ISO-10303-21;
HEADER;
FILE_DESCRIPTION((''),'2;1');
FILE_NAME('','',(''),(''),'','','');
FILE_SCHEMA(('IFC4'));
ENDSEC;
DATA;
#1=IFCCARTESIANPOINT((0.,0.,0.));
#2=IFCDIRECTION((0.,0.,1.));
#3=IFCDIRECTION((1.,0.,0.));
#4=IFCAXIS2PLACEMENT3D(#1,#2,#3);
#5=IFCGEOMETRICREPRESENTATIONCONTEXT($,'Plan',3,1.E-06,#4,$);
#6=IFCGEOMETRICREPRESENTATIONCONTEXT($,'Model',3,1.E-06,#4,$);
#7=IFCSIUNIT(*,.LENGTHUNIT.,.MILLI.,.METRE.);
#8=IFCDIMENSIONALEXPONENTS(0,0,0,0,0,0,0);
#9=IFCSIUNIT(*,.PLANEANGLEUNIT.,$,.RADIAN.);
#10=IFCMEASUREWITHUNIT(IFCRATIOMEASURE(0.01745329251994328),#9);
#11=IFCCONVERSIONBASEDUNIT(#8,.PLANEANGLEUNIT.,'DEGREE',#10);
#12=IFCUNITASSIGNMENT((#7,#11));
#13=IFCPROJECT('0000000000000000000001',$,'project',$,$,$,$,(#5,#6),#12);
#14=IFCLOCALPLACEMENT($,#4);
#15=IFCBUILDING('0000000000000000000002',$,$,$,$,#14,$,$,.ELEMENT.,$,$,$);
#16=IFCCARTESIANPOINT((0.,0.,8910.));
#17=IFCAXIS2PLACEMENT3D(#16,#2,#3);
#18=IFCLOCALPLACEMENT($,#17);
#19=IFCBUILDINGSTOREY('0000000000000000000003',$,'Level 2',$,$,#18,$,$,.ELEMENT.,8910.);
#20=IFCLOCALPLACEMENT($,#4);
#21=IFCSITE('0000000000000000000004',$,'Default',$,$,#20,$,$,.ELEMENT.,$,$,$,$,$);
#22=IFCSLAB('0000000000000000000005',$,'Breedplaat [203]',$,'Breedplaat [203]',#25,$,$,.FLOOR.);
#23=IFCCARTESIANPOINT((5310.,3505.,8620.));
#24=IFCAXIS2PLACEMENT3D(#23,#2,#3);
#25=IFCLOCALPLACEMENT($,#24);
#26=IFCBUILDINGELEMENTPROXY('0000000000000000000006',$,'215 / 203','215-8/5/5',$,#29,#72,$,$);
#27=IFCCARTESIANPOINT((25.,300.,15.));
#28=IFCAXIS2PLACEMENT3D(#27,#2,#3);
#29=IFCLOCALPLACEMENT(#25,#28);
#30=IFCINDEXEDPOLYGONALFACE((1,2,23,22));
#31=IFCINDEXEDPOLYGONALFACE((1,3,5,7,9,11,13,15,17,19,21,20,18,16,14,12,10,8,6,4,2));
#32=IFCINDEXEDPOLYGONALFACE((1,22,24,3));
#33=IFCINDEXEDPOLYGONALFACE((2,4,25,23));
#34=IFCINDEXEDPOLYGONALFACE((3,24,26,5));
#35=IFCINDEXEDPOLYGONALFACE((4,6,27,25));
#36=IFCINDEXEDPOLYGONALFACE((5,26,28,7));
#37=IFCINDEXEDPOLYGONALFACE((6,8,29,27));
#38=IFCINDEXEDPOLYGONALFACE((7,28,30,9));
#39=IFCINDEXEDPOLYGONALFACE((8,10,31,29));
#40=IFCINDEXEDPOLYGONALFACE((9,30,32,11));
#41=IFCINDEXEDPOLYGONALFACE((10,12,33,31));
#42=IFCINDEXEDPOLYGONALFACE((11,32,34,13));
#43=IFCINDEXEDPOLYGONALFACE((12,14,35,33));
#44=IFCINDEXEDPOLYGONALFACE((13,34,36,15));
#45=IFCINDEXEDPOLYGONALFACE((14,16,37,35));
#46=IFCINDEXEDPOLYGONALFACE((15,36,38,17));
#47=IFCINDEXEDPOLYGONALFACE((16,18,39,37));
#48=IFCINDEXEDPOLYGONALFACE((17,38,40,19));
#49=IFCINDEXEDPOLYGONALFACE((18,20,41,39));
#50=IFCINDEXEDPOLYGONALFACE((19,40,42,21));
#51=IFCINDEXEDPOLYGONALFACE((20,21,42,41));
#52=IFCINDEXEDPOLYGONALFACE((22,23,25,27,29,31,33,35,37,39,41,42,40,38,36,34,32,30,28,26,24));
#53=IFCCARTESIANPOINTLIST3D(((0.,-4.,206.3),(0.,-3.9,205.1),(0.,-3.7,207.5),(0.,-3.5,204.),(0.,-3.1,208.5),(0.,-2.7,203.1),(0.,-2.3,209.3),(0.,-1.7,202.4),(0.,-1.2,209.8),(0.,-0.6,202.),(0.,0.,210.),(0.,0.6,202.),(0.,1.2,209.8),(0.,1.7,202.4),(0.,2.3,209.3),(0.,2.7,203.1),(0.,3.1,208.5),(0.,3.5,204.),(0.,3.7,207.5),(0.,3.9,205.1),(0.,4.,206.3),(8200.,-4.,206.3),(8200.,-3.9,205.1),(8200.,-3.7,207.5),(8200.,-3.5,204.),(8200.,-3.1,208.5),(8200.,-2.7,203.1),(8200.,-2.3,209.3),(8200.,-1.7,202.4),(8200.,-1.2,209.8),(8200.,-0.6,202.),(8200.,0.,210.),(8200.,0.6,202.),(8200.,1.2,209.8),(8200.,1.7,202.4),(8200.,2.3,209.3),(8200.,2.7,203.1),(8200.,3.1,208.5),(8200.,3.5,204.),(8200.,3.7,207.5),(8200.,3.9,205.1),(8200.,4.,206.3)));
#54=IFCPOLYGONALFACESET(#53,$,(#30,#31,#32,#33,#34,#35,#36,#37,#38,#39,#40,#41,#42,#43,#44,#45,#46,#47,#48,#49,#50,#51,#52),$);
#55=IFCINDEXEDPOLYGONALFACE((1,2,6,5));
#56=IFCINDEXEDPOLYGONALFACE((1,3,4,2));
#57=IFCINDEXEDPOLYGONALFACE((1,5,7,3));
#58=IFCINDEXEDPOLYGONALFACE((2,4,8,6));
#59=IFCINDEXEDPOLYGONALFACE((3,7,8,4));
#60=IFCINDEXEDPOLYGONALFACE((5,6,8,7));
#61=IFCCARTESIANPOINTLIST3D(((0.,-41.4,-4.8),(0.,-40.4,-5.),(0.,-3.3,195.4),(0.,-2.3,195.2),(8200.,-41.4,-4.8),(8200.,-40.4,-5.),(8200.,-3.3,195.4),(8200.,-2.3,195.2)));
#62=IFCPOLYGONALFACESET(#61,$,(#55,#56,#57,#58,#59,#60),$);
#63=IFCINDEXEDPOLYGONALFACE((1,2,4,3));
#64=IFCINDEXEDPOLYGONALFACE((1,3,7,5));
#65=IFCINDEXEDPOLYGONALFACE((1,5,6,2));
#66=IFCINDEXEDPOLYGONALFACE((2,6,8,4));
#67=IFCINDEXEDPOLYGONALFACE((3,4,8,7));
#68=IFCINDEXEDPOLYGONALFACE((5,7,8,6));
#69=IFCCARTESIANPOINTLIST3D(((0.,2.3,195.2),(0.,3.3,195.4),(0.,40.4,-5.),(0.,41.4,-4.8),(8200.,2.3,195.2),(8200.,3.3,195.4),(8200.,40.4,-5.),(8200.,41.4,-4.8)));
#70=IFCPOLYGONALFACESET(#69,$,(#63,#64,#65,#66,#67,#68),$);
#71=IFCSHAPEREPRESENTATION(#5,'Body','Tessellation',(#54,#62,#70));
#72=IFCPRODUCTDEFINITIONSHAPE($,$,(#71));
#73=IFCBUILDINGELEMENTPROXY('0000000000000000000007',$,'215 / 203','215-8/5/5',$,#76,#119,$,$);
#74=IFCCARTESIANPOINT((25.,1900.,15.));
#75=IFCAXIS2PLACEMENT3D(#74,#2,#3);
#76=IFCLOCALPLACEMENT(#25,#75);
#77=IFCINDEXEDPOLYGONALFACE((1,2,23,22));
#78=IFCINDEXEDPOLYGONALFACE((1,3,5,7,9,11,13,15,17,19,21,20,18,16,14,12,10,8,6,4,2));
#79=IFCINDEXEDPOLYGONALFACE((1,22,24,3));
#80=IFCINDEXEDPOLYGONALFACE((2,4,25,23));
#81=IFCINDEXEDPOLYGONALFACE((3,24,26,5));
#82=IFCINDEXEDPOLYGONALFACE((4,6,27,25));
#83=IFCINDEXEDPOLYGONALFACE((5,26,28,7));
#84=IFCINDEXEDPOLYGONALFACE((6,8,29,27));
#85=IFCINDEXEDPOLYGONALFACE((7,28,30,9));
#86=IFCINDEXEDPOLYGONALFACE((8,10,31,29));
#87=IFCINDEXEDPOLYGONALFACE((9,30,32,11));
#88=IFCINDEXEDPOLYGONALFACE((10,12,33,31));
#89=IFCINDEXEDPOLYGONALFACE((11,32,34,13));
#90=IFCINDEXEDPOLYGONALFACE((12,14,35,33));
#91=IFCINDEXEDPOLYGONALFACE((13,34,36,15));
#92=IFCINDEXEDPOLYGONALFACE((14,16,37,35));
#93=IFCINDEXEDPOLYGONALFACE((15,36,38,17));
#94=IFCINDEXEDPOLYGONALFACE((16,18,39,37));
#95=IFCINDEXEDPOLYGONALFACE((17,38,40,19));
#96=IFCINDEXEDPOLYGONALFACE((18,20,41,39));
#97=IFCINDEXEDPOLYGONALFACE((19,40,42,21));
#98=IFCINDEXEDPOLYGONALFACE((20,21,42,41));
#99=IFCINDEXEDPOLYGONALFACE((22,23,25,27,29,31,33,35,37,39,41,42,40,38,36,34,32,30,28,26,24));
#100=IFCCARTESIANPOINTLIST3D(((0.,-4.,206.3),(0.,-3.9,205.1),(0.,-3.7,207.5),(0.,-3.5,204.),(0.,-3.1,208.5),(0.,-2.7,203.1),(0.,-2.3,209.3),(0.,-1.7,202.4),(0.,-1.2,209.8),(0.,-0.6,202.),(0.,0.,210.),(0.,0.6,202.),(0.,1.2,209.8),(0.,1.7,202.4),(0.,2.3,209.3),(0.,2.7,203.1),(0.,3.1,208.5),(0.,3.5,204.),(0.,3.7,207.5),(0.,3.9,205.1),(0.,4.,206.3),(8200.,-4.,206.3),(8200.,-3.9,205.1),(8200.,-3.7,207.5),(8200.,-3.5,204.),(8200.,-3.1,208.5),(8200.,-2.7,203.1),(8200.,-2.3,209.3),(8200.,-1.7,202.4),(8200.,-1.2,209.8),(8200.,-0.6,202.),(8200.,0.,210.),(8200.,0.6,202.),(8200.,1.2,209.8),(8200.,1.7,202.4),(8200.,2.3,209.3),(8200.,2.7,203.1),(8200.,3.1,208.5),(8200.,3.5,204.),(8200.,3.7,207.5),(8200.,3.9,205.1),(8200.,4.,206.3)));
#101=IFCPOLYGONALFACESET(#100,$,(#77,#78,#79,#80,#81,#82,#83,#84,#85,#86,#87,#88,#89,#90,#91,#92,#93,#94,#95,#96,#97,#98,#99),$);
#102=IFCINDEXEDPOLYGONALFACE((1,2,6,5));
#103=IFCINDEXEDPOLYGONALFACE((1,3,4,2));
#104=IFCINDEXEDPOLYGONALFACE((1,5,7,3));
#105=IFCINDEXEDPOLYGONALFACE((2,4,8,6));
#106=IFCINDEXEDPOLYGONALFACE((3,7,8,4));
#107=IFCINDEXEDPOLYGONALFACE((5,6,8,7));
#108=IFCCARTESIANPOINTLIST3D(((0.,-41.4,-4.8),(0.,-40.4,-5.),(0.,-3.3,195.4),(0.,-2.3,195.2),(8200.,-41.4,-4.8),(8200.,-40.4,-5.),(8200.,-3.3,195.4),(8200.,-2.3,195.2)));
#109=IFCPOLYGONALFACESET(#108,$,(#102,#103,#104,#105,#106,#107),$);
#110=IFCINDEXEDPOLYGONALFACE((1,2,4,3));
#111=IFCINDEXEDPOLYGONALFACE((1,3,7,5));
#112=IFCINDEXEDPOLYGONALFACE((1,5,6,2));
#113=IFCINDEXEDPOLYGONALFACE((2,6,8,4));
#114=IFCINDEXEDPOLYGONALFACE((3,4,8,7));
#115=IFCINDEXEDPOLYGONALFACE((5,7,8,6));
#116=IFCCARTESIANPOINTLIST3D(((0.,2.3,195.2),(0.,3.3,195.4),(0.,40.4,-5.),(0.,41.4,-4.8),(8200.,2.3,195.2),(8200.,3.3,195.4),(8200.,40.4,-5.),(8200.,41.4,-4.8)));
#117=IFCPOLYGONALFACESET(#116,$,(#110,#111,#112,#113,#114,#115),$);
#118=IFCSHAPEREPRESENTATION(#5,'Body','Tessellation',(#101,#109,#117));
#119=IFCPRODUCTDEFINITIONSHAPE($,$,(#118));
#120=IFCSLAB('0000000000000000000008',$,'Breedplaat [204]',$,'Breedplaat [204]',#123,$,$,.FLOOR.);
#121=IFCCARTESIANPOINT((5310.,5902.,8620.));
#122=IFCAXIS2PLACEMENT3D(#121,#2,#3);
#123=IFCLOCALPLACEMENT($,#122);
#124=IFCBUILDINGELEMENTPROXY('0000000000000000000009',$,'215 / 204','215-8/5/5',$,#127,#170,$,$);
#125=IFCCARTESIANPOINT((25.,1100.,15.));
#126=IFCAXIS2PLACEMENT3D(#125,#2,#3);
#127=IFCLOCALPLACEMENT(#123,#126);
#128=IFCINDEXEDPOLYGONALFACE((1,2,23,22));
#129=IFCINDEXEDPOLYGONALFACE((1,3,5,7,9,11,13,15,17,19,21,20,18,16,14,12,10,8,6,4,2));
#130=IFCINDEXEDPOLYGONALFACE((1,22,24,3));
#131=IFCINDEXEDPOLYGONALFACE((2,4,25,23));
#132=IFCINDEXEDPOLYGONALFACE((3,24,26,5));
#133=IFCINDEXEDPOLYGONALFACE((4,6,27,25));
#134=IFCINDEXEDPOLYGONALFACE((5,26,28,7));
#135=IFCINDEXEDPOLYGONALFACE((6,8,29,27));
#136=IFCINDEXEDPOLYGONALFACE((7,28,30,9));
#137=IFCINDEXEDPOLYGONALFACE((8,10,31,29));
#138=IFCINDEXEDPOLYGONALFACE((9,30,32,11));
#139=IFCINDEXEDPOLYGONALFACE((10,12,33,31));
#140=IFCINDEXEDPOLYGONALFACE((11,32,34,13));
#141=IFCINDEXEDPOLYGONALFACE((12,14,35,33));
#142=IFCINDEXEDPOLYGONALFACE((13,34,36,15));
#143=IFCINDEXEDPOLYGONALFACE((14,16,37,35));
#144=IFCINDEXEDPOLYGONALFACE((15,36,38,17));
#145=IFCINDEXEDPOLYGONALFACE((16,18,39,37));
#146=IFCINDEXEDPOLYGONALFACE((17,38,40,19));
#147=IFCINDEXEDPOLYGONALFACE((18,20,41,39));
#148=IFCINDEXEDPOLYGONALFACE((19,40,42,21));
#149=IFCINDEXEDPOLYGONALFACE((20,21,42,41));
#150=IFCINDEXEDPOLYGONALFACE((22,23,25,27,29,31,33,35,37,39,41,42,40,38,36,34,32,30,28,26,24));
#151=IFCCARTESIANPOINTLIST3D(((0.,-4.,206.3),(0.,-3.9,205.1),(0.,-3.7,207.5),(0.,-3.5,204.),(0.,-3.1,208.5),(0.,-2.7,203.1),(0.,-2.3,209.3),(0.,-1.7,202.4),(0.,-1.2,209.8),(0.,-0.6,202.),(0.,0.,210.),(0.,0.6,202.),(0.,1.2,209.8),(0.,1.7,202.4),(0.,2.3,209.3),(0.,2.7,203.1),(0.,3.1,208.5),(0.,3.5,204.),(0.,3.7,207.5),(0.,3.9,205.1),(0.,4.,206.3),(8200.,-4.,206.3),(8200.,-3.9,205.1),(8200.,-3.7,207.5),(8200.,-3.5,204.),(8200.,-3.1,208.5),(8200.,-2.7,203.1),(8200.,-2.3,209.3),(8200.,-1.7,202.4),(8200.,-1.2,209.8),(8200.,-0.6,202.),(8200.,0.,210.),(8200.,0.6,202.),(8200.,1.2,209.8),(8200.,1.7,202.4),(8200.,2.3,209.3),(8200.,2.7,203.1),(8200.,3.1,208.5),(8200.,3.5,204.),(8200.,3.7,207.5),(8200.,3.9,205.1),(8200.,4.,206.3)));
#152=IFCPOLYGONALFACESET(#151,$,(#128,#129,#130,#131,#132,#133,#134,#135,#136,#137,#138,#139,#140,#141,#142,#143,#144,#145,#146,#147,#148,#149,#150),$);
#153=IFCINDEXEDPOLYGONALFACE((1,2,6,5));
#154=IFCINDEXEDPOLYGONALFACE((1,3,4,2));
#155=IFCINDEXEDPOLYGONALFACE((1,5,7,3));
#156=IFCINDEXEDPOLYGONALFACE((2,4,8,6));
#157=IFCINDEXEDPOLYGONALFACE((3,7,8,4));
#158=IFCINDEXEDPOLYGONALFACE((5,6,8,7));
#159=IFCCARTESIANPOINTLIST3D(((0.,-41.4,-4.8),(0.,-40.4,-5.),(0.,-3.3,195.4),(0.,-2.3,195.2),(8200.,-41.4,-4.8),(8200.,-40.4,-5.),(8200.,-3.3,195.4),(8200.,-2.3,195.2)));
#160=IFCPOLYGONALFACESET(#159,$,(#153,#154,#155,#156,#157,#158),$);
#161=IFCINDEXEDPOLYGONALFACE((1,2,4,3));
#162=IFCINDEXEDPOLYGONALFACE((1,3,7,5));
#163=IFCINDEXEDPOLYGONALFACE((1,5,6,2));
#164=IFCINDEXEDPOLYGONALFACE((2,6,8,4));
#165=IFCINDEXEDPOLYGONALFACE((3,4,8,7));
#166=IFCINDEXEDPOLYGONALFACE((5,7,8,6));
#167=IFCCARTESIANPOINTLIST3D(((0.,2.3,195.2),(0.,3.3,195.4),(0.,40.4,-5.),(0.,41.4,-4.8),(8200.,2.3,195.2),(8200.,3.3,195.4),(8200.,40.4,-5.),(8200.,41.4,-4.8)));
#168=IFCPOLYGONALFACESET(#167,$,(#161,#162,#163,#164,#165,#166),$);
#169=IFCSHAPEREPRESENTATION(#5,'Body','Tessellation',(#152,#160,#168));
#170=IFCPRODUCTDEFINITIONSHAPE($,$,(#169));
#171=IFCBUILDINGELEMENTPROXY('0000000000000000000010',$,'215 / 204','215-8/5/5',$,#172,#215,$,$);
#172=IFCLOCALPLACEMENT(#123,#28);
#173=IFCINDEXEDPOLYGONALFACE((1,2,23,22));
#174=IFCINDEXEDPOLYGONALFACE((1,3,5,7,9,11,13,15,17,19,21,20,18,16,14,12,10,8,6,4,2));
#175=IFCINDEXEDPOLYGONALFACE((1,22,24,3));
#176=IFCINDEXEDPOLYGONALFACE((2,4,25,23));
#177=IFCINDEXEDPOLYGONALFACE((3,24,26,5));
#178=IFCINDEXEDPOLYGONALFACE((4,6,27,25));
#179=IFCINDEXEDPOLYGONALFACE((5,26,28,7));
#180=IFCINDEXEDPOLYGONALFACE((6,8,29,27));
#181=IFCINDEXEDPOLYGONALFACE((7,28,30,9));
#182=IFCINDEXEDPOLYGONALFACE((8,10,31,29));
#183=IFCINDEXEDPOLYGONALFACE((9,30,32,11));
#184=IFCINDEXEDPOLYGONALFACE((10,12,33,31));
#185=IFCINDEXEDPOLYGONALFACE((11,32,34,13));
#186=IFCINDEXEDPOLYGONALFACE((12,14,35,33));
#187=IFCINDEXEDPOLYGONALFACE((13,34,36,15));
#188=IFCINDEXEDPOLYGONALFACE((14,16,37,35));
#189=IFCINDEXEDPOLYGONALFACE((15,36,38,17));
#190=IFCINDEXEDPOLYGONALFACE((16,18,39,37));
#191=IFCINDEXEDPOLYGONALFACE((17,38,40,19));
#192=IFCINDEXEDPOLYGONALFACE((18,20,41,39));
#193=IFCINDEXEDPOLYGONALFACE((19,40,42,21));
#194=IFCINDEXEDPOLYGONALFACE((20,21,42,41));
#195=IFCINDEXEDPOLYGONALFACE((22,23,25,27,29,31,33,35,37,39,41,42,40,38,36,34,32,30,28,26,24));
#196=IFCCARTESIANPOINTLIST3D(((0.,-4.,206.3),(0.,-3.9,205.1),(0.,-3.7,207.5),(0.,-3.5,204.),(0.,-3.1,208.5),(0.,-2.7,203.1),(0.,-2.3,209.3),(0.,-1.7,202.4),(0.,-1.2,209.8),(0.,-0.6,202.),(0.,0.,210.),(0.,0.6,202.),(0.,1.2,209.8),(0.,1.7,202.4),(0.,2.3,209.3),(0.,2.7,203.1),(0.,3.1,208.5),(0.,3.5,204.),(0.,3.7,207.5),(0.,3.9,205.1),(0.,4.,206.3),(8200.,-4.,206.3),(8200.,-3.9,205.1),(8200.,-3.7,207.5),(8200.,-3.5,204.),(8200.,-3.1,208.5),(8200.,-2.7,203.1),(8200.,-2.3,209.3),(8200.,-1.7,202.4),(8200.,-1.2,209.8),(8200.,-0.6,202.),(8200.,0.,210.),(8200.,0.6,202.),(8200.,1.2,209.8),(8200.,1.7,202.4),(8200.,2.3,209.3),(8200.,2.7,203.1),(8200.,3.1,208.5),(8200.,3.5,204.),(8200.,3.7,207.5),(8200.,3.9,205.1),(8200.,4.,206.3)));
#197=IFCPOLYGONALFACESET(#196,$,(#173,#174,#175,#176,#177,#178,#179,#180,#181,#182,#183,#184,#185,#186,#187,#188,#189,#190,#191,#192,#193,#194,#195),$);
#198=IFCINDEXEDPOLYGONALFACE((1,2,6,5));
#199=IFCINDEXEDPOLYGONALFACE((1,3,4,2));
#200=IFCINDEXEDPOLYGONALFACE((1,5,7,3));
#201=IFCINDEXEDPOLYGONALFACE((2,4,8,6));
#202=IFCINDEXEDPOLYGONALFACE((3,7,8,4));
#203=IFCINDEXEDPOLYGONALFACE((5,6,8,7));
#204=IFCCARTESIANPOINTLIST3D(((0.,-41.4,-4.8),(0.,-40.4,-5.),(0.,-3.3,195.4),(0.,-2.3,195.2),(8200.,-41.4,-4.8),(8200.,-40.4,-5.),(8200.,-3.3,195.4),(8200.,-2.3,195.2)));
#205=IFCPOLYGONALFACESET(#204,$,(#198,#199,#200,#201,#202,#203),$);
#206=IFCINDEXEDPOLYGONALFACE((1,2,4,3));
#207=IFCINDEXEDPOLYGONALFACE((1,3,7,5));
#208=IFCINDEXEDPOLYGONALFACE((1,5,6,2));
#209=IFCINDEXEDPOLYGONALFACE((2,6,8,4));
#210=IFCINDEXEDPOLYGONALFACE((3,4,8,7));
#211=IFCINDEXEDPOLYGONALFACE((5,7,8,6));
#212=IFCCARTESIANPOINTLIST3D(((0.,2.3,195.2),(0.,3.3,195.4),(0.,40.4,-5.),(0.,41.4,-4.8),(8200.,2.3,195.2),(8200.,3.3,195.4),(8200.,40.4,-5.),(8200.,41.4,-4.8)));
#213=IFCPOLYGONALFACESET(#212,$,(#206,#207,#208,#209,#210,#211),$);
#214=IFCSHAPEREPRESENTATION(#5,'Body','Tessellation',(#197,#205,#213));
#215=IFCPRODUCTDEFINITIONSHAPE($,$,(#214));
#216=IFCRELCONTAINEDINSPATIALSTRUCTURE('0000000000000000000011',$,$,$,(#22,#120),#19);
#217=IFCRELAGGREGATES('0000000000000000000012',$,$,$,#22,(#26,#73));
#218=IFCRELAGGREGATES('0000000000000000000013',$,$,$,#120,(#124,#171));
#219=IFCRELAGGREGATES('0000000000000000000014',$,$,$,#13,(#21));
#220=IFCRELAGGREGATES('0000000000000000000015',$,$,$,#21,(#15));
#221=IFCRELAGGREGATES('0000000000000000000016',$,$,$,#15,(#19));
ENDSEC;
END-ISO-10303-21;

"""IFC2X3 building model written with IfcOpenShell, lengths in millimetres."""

from ifc_helpers import new_model, entity, si_unit, converted_unit, frame, origin_with_axes, origin_2d_with_axis, place, context, project, spatial, rectangle, circle, extrude, element, aggregate, save


model = new_model("IFC2X3")

# Units and contexts
plan_context = context("Plan", 3, precision=1e-06, world=origin_with_axes())
model_context = context("Model", 3, precision=1e-06, world=origin_with_axes())
ifc_project = project(units=[si_unit("LENGTHUNIT", "METRE", prefix="MILLI"), converted_unit("PLANEANGLEUNIT", "DEGREE", entity("IfcRatioMeasure", 0.01745329251994328), si_unit("PLANEANGLEUNIT", "RADIAN"), dimensions=[0, 0, 0, 0, 0, 0, 0])], contexts=[plan_context, model_context])

# Site, building, storey
site_placement = place(None, origin_with_axes())
site = spatial("IfcSite", under=ifc_project, at=site_placement, Name="Default", CompositionType="ELEMENT")
building_placement = place(None, origin_with_axes())
building = spatial("IfcBuilding", under=site, at=building_placement, CompositionType="ELEMENT")
storey_placement = place(None, frame((0.0, 0.0, 8910.0), z_axis=(0.0, 0.0, 1.0), x_axis=(1.0, 0.0, 0.0)))
storey = spatial("IfcBuildingStorey", under=building, at=storey_placement, Name="Level 2", CompositionType="ELEMENT", Elevation=8910.0)

# Slabs, building element proxies
slab_1_placement = place(None, frame((5310.0, 3505.0, 8620.0), z_axis=(0.0, 0.0, 1.0), x_axis=(1.0, 0.0, 0.0)))
slab_1 = element("IfcSlab", 1, at=slab_1_placement, inside=storey, Name="Breedplaat [203]", ObjectType="Breedplaat [203]", PredefinedType="FLOOR")
proxy_1_placement = place(slab_1_placement, frame((25.0, 300.0, 15.0), z_axis=(0.0, 0.0, 1.0), x_axis=(1.0, 0.0, 0.0)))
proxy_1 = element("IfcBuildingElementProxy", 2, at=proxy_1_placement, Name="215 / 203", Description="215-8/5/5", context=plan_context, shape_type="SweptSolid", body=[
    extrude(circle(Radius=4.0, at=origin_2d_with_axis()), frame((0.0, 0.0, 206.0), z_axis=(1.0, 0.0, 0.0), x_axis=(0.0, 0.0, 1.0)), (0.0, 0.0, 1.0), 8200.0),
    extrude(rectangle(XDim=203.8, YDim=1.0, at=origin_2d_with_axis()), frame((0.0, -21.9, 95.2), z_axis=(1.0, 0.0, 0.0), x_axis=(0.0, 0.187112, 0.982339)), (0.0, 0.0, 1.0), 8200.0),
    extrude(rectangle(XDim=203.8, YDim=1.0, at=origin_2d_with_axis()), frame((0.0, 21.9, 95.2), z_axis=(1.0, 0.0, 0.0), x_axis=(0.0, -0.187112, 0.982339)), (0.0, 0.0, 1.0), 8200.0),
])
proxy_2_placement = place(slab_1_placement, frame((25.0, 1900.0, 15.0), z_axis=(0.0, 0.0, 1.0), x_axis=(1.0, 0.0, 0.0)))
proxy_2 = element("IfcBuildingElementProxy", 3, at=proxy_2_placement, Name="215 / 203", Description="215-8/5/5", context=plan_context, shape_type="SweptSolid", body=[
    extrude(circle(Radius=4.0, at=origin_2d_with_axis()), frame((0.0, 0.0, 206.0), z_axis=(1.0, 0.0, 0.0), x_axis=(0.0, 0.0, 1.0)), (0.0, 0.0, 1.0), 8200.0),
    extrude(rectangle(XDim=203.8, YDim=1.0, at=origin_2d_with_axis()), frame((0.0, -21.9, 95.2), z_axis=(1.0, 0.0, 0.0), x_axis=(0.0, 0.187112, 0.982339)), (0.0, 0.0, 1.0), 8200.0),
    extrude(rectangle(XDim=203.8, YDim=1.0, at=origin_2d_with_axis()), frame((0.0, 21.9, 95.2), z_axis=(1.0, 0.0, 0.0), x_axis=(0.0, -0.187112, 0.982339)), (0.0, 0.0, 1.0), 8200.0),
])
aggregate(slab_1, [proxy_1, proxy_2])
slab_2_placement = place(None, frame((5310.0, 5902.0, 8620.0), z_axis=(0.0, 0.0, 1.0), x_axis=(1.0, 0.0, 0.0)))
slab_2 = element("IfcSlab", 4, at=slab_2_placement, inside=storey, Name="Breedplaat [204]", ObjectType="Breedplaat [204]", PredefinedType="FLOOR")
proxy_3_placement = place(slab_2_placement, frame((25.0, 1100.0, 15.0), z_axis=(0.0, 0.0, 1.0), x_axis=(1.0, 0.0, 0.0)))
proxy_3 = element("IfcBuildingElementProxy", 5, at=proxy_3_placement, Name="215 / 204", Description="215-8/5/5", context=plan_context, shape_type="SweptSolid", body=[
    extrude(circle(Radius=4.0, at=origin_2d_with_axis()), frame((0.0, 0.0, 206.0), z_axis=(1.0, 0.0, 0.0), x_axis=(0.0, 0.0, 1.0)), (0.0, 0.0, 1.0), 8200.0),
    extrude(rectangle(XDim=203.8, YDim=1.0, at=origin_2d_with_axis()), frame((0.0, -21.9, 95.2), z_axis=(1.0, 0.0, 0.0), x_axis=(0.0, 0.187112, 0.982339)), (0.0, 0.0, 1.0), 8200.0),
    extrude(rectangle(XDim=203.8, YDim=1.0, at=origin_2d_with_axis()), frame((0.0, 21.9, 95.2), z_axis=(1.0, 0.0, 0.0), x_axis=(0.0, -0.187112, 0.982339)), (0.0, 0.0, 1.0), 8200.0),
])
proxy_4_placement = place(slab_2_placement, frame((25.0, 300.0, 15.0), z_axis=(0.0, 0.0, 1.0), x_axis=(1.0, 0.0, 0.0)))
proxy_4 = element("IfcBuildingElementProxy", 6, at=proxy_4_placement, Name="215 / 204", Description="215-8/5/5", context=plan_context, shape_type="SweptSolid", body=[
    extrude(circle(Radius=4.0, at=origin_2d_with_axis()), frame((0.0, 0.0, 206.0), z_axis=(1.0, 0.0, 0.0), x_axis=(0.0, 0.0, 1.0)), (0.0, 0.0, 1.0), 8200.0),
    extrude(rectangle(XDim=203.8, YDim=1.0, at=origin_2d_with_axis()), frame((0.0, -21.9, 95.2), z_axis=(1.0, 0.0, 0.0), x_axis=(0.0, 0.187112, 0.982339)), (0.0, 0.0, 1.0), 8200.0),
    extrude(rectangle(XDim=203.8, YDim=1.0, at=origin_2d_with_axis()), frame((0.0, 21.9, 95.2), z_axis=(1.0, 0.0, 0.0), x_axis=(0.0, -0.187112, 0.982339)), (0.0, 0.0, 1.0), 8200.0),
])
aggregate(slab_2, [proxy_3, proxy_4])

save(model, "model.ifc")
